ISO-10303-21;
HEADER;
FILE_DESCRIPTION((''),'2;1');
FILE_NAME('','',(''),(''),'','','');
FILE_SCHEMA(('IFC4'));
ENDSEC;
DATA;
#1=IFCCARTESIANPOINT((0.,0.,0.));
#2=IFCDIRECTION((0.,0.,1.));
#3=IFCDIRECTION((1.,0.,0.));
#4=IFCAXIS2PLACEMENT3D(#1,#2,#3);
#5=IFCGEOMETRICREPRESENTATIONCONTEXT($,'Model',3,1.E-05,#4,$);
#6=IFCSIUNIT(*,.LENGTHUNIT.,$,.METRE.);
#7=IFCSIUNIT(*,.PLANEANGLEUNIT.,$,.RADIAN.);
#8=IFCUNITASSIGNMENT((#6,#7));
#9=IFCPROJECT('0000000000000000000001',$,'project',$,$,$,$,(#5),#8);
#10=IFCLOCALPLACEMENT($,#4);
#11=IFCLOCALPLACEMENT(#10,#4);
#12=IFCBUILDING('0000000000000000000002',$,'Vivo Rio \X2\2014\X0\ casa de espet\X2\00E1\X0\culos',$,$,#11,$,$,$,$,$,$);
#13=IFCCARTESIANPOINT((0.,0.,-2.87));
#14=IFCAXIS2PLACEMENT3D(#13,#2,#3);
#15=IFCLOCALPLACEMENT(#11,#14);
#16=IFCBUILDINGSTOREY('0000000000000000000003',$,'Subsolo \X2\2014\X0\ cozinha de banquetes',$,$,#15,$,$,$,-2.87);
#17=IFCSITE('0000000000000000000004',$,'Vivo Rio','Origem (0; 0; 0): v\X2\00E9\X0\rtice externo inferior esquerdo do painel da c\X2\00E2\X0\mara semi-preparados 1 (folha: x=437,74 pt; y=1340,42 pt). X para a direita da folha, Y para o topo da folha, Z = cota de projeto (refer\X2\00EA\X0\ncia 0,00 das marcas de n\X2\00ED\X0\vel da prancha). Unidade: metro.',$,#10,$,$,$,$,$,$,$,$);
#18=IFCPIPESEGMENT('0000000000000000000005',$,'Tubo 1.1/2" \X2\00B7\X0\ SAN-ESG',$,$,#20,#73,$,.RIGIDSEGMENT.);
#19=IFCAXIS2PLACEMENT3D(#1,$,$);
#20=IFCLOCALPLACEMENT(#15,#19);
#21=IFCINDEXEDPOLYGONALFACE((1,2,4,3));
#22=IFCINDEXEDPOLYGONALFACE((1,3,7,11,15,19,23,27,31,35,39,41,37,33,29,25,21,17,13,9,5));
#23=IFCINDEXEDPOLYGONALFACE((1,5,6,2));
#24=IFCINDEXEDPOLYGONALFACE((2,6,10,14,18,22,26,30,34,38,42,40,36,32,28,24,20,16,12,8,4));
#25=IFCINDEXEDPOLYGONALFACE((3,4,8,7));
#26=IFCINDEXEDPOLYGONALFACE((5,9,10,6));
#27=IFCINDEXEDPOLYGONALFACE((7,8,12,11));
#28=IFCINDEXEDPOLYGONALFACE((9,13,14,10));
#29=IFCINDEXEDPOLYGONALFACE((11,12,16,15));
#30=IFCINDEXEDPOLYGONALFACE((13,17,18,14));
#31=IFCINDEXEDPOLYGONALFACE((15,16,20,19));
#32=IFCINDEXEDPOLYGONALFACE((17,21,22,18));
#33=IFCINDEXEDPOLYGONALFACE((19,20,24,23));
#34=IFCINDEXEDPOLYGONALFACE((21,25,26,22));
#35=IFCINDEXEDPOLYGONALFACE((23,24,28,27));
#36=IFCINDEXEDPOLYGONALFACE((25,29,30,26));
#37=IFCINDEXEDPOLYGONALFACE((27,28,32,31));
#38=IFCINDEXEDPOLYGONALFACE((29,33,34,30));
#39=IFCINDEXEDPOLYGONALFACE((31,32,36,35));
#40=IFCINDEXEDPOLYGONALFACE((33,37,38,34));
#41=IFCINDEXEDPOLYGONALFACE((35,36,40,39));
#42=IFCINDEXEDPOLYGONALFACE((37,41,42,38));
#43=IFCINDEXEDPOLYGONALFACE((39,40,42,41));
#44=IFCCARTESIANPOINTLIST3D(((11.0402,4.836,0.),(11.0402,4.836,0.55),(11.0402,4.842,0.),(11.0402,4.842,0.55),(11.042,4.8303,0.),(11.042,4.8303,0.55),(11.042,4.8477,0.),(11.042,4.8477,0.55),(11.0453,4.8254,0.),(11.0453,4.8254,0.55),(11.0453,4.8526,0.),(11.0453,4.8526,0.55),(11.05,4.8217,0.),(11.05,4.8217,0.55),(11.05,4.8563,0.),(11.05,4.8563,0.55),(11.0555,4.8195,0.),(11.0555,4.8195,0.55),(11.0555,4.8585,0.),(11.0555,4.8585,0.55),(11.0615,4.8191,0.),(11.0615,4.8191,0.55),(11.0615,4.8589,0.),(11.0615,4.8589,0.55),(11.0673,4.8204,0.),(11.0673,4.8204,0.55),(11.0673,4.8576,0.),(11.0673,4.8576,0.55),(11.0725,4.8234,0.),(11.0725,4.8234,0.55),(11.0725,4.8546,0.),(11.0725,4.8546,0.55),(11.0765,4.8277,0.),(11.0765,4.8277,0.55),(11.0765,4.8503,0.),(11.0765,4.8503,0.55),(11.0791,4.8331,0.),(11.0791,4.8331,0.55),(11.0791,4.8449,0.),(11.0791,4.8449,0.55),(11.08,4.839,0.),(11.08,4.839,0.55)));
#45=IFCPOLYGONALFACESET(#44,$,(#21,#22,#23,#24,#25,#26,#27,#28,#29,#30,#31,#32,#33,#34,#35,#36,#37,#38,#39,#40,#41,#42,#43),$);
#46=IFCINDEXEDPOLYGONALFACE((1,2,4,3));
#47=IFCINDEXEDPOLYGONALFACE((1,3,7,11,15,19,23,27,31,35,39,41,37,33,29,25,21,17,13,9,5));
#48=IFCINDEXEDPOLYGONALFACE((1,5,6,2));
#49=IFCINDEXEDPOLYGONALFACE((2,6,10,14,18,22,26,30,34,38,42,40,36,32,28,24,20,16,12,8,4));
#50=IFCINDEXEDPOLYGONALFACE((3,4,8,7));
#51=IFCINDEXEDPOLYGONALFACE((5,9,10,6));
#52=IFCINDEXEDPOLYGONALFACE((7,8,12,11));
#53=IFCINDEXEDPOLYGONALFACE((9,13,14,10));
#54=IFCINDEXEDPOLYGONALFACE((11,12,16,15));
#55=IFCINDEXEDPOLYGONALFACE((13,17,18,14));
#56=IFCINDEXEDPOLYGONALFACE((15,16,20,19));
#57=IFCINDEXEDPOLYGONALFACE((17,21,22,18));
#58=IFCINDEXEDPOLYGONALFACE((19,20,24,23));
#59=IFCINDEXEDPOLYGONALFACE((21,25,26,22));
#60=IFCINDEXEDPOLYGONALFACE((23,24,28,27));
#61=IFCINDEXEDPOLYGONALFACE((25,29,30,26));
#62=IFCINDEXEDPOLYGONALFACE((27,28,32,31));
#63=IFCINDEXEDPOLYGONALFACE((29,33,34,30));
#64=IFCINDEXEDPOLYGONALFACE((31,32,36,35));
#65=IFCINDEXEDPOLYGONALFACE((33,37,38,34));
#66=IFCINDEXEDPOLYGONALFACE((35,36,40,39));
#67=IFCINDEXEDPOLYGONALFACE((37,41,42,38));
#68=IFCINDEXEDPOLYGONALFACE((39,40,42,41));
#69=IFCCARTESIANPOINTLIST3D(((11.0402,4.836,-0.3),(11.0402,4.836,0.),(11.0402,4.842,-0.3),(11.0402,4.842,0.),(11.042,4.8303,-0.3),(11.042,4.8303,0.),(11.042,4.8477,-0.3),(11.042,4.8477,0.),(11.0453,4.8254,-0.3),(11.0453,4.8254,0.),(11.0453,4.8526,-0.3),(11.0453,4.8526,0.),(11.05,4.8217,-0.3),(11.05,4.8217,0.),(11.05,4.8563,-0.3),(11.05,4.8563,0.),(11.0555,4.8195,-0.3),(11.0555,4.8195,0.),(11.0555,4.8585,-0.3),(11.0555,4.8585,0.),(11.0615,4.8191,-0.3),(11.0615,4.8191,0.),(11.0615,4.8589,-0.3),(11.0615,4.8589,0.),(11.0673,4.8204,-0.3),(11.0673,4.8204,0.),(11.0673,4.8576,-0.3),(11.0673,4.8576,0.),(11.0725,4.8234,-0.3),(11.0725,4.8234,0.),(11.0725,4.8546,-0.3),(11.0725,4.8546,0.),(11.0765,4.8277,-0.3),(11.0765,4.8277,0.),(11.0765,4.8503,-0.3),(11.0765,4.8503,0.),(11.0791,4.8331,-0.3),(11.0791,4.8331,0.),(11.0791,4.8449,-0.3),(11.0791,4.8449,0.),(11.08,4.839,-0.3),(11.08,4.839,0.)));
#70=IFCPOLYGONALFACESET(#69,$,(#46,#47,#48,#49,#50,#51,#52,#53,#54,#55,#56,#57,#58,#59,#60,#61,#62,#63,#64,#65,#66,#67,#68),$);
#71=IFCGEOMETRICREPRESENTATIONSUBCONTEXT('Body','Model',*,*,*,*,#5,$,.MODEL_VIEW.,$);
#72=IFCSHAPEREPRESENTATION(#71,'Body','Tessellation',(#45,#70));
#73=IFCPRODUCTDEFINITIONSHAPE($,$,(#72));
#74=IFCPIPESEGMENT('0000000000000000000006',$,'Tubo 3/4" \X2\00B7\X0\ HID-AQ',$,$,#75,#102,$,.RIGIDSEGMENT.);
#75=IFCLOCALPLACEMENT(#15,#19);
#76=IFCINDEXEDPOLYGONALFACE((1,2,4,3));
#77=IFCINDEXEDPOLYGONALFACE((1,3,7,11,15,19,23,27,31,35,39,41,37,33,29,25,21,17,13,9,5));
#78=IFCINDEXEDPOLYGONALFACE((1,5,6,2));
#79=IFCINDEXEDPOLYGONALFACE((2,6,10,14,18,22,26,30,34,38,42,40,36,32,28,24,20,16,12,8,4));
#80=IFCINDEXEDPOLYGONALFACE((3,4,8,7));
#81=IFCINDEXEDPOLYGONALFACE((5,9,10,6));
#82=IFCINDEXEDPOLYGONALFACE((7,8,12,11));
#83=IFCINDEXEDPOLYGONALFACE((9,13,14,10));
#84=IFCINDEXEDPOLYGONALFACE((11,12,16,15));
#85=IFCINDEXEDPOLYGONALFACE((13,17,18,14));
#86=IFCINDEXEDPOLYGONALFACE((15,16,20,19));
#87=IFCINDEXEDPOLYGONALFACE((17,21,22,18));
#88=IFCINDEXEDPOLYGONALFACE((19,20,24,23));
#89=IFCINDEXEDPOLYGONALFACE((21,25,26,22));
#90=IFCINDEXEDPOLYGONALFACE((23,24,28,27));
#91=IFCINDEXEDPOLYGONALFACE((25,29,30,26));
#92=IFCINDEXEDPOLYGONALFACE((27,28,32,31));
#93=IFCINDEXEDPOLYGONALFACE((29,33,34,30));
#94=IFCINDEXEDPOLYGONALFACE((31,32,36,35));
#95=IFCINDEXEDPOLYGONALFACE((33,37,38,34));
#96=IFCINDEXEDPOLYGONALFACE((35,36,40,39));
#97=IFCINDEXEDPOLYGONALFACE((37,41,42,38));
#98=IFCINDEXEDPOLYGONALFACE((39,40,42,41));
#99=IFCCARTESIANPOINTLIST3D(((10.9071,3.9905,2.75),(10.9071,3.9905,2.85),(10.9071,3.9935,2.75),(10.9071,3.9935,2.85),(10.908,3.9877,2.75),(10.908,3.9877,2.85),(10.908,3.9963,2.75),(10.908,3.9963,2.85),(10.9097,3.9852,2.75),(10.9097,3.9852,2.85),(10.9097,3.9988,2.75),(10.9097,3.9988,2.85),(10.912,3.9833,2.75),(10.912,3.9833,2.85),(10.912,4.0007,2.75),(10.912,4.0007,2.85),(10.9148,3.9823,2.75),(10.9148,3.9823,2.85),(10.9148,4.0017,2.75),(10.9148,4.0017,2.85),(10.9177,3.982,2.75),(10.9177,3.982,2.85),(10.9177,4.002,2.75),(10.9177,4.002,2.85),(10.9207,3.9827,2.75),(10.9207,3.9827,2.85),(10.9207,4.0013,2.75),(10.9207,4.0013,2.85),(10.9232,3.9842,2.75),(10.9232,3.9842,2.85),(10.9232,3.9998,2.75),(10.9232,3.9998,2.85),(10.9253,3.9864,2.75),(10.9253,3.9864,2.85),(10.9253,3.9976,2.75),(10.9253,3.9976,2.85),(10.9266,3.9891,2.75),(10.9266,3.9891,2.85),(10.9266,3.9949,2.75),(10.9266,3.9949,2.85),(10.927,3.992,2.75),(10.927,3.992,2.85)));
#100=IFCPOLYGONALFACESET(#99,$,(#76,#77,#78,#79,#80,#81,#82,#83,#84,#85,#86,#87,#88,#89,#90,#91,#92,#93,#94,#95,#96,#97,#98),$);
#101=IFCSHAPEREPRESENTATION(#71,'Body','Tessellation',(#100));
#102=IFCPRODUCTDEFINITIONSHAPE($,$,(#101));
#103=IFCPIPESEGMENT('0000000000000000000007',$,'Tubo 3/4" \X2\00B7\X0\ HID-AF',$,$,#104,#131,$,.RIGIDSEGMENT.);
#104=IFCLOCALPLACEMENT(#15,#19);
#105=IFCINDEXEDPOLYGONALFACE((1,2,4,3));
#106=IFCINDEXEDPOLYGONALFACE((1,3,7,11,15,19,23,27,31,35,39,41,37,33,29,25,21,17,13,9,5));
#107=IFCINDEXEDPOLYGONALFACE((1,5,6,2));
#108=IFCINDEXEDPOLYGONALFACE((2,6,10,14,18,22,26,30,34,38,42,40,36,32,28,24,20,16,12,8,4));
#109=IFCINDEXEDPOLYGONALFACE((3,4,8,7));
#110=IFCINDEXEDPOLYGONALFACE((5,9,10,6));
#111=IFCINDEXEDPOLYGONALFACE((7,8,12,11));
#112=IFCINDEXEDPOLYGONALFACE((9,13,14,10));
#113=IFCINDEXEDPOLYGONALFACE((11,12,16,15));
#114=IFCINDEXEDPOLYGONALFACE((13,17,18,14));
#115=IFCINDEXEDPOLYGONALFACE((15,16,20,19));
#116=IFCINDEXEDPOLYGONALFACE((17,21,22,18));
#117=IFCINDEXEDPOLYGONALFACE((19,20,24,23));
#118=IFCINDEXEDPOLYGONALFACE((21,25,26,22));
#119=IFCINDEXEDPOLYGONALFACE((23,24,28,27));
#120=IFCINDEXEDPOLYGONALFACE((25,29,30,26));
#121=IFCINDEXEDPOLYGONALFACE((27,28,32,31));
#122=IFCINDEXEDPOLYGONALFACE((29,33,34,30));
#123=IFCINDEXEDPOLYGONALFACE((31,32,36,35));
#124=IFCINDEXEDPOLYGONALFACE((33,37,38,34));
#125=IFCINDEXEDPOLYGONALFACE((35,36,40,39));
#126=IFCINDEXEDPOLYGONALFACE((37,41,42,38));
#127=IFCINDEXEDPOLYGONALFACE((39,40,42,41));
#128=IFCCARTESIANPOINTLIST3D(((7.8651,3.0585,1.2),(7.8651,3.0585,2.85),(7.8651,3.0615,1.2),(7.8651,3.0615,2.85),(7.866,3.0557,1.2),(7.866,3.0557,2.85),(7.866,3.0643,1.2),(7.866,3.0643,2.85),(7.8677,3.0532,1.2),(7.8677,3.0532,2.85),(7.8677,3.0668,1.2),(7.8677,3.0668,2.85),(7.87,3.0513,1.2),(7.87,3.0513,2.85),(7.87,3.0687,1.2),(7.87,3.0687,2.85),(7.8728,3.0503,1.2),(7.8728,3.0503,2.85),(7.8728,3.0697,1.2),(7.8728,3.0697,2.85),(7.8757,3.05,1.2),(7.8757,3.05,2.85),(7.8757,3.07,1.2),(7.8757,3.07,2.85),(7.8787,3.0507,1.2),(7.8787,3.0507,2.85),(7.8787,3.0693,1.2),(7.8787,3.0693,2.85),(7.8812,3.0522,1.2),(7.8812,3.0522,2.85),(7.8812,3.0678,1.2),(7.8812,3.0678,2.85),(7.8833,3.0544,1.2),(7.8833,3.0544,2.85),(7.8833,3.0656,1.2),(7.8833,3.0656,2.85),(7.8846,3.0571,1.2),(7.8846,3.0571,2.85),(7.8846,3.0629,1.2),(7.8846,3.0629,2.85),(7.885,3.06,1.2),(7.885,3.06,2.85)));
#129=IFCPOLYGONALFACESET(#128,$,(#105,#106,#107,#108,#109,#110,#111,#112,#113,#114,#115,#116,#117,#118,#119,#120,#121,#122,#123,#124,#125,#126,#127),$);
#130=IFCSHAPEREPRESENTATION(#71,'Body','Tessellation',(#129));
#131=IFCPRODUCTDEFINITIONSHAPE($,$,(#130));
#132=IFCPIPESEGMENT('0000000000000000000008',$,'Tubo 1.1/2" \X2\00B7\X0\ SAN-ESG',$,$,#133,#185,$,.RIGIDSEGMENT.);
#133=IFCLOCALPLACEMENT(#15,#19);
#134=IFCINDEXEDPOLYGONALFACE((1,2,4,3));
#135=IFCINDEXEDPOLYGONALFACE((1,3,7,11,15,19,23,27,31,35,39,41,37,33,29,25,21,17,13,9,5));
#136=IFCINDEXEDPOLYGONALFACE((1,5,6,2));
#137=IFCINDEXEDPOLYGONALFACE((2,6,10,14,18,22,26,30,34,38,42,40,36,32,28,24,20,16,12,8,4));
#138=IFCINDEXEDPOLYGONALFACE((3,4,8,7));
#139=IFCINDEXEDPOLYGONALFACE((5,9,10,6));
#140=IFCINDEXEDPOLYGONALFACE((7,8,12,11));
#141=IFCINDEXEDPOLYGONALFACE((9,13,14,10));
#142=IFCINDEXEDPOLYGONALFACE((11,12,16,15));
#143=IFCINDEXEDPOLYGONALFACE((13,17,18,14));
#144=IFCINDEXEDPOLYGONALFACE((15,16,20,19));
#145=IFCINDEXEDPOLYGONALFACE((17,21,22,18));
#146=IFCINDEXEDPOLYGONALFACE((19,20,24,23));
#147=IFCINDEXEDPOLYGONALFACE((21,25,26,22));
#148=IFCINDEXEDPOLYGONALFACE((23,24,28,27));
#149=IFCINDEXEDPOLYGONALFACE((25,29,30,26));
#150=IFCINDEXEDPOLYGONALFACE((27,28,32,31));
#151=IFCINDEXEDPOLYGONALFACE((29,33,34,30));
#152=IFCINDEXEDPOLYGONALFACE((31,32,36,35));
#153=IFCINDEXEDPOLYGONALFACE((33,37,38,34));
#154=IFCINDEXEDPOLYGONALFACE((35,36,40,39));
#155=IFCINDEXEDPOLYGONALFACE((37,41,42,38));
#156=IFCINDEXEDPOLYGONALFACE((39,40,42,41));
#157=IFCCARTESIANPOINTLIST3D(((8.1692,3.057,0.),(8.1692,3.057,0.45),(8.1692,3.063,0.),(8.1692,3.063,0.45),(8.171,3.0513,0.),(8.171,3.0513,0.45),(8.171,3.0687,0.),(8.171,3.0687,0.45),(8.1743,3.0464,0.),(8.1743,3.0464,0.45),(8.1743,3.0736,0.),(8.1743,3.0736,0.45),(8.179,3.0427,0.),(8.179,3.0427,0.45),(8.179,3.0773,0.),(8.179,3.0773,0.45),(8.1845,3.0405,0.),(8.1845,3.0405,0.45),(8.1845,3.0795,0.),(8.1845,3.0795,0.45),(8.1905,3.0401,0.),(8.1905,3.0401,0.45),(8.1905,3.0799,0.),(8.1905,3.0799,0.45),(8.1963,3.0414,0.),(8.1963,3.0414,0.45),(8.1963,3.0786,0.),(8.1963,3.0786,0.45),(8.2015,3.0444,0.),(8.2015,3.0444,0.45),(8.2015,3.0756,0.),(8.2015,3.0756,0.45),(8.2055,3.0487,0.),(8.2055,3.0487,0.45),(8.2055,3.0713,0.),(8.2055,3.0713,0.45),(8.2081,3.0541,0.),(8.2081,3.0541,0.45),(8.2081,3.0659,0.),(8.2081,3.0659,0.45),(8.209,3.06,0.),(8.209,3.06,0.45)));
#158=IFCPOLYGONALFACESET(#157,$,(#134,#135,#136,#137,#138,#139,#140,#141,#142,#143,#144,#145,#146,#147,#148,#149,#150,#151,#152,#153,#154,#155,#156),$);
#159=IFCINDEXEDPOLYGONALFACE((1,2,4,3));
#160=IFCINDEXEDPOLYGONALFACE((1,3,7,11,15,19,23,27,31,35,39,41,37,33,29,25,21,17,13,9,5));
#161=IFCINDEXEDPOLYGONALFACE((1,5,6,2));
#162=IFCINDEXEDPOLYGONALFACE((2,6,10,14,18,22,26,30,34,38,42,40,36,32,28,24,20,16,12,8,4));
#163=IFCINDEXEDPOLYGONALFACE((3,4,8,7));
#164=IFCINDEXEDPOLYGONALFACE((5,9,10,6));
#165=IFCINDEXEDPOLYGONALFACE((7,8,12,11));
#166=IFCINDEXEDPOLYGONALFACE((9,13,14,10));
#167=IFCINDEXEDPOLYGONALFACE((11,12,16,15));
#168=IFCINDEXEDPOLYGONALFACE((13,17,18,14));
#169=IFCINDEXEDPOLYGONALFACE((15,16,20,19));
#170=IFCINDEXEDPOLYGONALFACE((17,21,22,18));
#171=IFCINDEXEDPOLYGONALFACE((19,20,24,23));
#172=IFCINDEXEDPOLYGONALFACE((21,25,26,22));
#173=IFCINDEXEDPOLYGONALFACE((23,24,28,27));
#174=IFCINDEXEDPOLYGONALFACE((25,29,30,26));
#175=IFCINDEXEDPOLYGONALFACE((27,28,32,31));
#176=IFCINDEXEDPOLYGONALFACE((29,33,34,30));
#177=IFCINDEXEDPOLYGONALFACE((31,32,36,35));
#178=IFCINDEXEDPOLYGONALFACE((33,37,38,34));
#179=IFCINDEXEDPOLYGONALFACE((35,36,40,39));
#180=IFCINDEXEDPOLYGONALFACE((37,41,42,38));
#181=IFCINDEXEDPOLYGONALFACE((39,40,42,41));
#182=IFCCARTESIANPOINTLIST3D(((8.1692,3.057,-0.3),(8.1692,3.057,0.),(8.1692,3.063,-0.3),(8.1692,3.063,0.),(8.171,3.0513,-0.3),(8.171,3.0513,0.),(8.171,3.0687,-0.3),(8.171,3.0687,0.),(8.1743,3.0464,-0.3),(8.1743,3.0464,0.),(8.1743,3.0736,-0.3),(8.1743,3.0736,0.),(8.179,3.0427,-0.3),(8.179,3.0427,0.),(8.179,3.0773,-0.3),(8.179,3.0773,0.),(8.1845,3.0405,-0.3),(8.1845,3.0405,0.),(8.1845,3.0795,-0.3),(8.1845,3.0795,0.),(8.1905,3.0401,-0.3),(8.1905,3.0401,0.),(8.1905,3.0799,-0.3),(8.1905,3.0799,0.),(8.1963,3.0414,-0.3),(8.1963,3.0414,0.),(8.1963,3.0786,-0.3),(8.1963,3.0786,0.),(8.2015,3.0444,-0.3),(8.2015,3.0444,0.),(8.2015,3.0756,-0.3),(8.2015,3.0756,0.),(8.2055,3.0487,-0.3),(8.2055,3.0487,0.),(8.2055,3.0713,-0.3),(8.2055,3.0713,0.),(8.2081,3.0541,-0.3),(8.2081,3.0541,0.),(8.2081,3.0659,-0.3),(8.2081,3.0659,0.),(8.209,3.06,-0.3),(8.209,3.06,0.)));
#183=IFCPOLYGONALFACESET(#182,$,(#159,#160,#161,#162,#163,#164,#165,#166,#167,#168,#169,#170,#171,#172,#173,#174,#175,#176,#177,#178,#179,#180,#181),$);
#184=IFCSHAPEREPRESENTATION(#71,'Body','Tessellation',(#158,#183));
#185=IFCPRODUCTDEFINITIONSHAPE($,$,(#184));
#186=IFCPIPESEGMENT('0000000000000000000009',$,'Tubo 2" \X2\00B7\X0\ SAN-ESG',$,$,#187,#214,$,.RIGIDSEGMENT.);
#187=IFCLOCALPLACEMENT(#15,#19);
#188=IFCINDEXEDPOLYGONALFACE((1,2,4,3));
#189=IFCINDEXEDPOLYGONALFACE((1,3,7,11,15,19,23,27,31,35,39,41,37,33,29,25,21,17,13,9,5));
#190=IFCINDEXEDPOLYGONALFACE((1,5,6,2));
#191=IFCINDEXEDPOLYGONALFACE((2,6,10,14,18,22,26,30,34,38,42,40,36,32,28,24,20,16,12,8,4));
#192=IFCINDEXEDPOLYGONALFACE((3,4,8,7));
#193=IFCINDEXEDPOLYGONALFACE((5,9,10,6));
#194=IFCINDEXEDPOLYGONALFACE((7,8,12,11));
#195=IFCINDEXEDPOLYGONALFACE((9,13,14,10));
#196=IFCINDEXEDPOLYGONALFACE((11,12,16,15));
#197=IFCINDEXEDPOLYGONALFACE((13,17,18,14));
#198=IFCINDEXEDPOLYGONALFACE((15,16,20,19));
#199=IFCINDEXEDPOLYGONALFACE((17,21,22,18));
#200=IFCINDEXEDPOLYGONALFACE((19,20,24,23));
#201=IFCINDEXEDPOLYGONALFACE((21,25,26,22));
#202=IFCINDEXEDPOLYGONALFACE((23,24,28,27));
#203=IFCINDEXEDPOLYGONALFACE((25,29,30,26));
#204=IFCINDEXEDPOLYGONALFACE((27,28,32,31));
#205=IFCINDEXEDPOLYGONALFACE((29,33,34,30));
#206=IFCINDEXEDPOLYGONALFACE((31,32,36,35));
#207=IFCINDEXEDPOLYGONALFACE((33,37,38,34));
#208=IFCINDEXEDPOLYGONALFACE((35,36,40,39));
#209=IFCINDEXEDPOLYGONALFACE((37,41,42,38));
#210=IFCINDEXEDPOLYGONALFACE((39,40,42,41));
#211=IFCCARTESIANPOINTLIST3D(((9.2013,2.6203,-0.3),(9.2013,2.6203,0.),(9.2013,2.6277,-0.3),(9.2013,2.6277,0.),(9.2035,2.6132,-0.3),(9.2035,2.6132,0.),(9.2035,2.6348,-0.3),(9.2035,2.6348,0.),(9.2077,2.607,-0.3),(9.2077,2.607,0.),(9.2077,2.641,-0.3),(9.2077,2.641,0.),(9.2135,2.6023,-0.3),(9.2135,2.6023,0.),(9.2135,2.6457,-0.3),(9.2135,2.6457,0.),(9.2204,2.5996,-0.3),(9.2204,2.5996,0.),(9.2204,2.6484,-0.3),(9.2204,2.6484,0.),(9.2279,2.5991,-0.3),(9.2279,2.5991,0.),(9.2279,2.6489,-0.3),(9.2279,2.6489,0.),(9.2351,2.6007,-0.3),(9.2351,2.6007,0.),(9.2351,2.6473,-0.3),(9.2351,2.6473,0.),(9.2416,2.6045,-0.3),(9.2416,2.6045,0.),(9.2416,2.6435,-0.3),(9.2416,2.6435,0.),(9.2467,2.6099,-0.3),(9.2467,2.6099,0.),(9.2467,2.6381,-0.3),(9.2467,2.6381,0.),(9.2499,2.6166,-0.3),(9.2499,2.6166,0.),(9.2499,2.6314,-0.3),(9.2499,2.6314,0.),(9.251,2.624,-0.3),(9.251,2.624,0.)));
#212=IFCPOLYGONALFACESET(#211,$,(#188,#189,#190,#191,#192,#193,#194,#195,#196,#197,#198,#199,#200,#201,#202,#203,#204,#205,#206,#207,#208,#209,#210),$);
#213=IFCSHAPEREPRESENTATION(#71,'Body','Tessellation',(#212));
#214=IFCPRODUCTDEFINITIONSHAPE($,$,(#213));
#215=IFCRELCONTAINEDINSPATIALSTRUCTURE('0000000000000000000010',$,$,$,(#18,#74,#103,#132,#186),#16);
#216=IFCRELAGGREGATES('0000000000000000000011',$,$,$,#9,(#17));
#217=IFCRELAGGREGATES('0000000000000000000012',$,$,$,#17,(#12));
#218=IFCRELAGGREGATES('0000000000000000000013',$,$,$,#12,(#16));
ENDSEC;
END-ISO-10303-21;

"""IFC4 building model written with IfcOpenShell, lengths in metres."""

from ifc_helpers import new_model, si_unit, frame, origin_with_axes, origin_2d, place, context, subcontext, project, spatial, circle, extrude, element, save


model = new_model("IFC4")

# Units and contexts
model_context = context("Model", 3, precision=1e-05, world=origin_with_axes())
body_context = subcontext(model_context, "Body", "Model", "MODEL_VIEW")
ifc_project = project(units=[si_unit("LENGTHUNIT", "METRE"), si_unit("PLANEANGLEUNIT", "RADIAN")], contexts=[model_context])

# Site, building, storey
site_placement = place(None, origin_with_axes())
site = spatial("IfcSite", under=ifc_project, at=site_placement, Name="Vivo Rio", Description="Origem (0; 0; 0): vértice externo inferior esquerdo do painel da câmara semi-preparados 1 (folha: x=437,74 pt; y=1340,42 pt). X para a direita da folha, Y para o topo da folha, Z = cota de projeto (referência 0,00 das marcas de nível da prancha). Unidade: metro.")
building_placement = place(site_placement, origin_with_axes())
building = spatial("IfcBuilding", under=site, at=building_placement, Name="Vivo Rio — casa de espetáculos")
storey_placement = place(building_placement, frame((0.0, 0.0, -2.87), z_axis=(0.0, 0.0, 1.0), x_axis=(1.0, 0.0, 0.0)))
storey = spatial("IfcBuildingStorey", under=building, at=storey_placement, Name="Subsolo — cozinha de banquetes", Elevation=-2.87)

# Pipe segments
pipe_segment_1_placement = place(storey_placement, origin_with_axes())
element("IfcPipeSegment", 1, at=pipe_segment_1_placement, inside=storey, Name="Tubo 1.1/2\" · SAN-ESG", PredefinedType="RIGIDSEGMENT", context=body_context, shape_type="SweptSolid", body=[
    extrude(circle(Radius=0.02, at=origin_2d()), frame((11.06, 4.839, 0.55), z_axis=(0.0, 0.0, -1.0), x_axis=(1.0, 0.0, 0.0)), (0.0, 0.0, 1.0), 0.55),
    extrude(circle(Radius=0.02, at=origin_2d()), frame((11.06, 4.839, 0.0), z_axis=(0.0, 0.0, -1.0), x_axis=(1.0, 0.0, 0.0)), (0.0, 0.0, 1.0), 0.3),
])
pipe_segment_2_placement = place(storey_placement, origin_with_axes())
element("IfcPipeSegment", 2, at=pipe_segment_2_placement, inside=storey, Name="Tubo 3/4\" · HID-AQ", PredefinedType="RIGIDSEGMENT", context=body_context, shape_type="SweptSolid", body=[
    extrude(circle(Radius=0.01, at=origin_2d()), frame((10.917, 3.992, 2.85), z_axis=(0.0, 0.0, -1.0), x_axis=(1.0, 0.0, 0.0)), (0.0, 0.0, 1.0), 0.1),
])
pipe_segment_3_placement = place(storey_placement, origin_with_axes())
element("IfcPipeSegment", 3, at=pipe_segment_3_placement, inside=storey, Name="Tubo 3/4\" · HID-AF", PredefinedType="RIGIDSEGMENT", context=body_context, shape_type="SweptSolid", body=[
    extrude(circle(Radius=0.01, at=origin_2d()), frame((7.875, 3.06, 2.85), z_axis=(0.0, 0.0, -1.0), x_axis=(1.0, 0.0, 0.0)), (0.0, 0.0, 1.0), 1.65),
])
pipe_segment_4_placement = place(storey_placement, origin_with_axes())
element("IfcPipeSegment", 4, at=pipe_segment_4_placement, inside=storey, Name="Tubo 1.1/2\" · SAN-ESG", PredefinedType="RIGIDSEGMENT", context=body_context, shape_type="SweptSolid", body=[
    extrude(circle(Radius=0.02, at=origin_2d()), frame((8.189, 3.06, 0.45), z_axis=(0.0, 0.0, -1.0), x_axis=(1.0, 0.0, 0.0)), (0.0, 0.0, 1.0), 0.45),
    extrude(circle(Radius=0.02, at=origin_2d()), frame((8.189, 3.06, 0.0), z_axis=(0.0, 0.0, -1.0), x_axis=(1.0, 0.0, 0.0)), (0.0, 0.0, 1.0), 0.3),
])
pipe_segment_5_placement = place(storey_placement, origin_with_axes())
element("IfcPipeSegment", 5, at=pipe_segment_5_placement, inside=storey, Name="Tubo 2\" · SAN-ESG", PredefinedType="RIGIDSEGMENT", context=body_context, shape_type="SweptSolid", body=[
    extrude(circle(Radius=0.025, at=origin_2d()), frame((9.226, 2.624, 0.0), z_axis=(0.0, 0.0, -1.0), x_axis=(1.0, 0.0, 0.0)), (0.0, 0.0, 1.0), 0.3),
])

save(model, "model.ifc")
